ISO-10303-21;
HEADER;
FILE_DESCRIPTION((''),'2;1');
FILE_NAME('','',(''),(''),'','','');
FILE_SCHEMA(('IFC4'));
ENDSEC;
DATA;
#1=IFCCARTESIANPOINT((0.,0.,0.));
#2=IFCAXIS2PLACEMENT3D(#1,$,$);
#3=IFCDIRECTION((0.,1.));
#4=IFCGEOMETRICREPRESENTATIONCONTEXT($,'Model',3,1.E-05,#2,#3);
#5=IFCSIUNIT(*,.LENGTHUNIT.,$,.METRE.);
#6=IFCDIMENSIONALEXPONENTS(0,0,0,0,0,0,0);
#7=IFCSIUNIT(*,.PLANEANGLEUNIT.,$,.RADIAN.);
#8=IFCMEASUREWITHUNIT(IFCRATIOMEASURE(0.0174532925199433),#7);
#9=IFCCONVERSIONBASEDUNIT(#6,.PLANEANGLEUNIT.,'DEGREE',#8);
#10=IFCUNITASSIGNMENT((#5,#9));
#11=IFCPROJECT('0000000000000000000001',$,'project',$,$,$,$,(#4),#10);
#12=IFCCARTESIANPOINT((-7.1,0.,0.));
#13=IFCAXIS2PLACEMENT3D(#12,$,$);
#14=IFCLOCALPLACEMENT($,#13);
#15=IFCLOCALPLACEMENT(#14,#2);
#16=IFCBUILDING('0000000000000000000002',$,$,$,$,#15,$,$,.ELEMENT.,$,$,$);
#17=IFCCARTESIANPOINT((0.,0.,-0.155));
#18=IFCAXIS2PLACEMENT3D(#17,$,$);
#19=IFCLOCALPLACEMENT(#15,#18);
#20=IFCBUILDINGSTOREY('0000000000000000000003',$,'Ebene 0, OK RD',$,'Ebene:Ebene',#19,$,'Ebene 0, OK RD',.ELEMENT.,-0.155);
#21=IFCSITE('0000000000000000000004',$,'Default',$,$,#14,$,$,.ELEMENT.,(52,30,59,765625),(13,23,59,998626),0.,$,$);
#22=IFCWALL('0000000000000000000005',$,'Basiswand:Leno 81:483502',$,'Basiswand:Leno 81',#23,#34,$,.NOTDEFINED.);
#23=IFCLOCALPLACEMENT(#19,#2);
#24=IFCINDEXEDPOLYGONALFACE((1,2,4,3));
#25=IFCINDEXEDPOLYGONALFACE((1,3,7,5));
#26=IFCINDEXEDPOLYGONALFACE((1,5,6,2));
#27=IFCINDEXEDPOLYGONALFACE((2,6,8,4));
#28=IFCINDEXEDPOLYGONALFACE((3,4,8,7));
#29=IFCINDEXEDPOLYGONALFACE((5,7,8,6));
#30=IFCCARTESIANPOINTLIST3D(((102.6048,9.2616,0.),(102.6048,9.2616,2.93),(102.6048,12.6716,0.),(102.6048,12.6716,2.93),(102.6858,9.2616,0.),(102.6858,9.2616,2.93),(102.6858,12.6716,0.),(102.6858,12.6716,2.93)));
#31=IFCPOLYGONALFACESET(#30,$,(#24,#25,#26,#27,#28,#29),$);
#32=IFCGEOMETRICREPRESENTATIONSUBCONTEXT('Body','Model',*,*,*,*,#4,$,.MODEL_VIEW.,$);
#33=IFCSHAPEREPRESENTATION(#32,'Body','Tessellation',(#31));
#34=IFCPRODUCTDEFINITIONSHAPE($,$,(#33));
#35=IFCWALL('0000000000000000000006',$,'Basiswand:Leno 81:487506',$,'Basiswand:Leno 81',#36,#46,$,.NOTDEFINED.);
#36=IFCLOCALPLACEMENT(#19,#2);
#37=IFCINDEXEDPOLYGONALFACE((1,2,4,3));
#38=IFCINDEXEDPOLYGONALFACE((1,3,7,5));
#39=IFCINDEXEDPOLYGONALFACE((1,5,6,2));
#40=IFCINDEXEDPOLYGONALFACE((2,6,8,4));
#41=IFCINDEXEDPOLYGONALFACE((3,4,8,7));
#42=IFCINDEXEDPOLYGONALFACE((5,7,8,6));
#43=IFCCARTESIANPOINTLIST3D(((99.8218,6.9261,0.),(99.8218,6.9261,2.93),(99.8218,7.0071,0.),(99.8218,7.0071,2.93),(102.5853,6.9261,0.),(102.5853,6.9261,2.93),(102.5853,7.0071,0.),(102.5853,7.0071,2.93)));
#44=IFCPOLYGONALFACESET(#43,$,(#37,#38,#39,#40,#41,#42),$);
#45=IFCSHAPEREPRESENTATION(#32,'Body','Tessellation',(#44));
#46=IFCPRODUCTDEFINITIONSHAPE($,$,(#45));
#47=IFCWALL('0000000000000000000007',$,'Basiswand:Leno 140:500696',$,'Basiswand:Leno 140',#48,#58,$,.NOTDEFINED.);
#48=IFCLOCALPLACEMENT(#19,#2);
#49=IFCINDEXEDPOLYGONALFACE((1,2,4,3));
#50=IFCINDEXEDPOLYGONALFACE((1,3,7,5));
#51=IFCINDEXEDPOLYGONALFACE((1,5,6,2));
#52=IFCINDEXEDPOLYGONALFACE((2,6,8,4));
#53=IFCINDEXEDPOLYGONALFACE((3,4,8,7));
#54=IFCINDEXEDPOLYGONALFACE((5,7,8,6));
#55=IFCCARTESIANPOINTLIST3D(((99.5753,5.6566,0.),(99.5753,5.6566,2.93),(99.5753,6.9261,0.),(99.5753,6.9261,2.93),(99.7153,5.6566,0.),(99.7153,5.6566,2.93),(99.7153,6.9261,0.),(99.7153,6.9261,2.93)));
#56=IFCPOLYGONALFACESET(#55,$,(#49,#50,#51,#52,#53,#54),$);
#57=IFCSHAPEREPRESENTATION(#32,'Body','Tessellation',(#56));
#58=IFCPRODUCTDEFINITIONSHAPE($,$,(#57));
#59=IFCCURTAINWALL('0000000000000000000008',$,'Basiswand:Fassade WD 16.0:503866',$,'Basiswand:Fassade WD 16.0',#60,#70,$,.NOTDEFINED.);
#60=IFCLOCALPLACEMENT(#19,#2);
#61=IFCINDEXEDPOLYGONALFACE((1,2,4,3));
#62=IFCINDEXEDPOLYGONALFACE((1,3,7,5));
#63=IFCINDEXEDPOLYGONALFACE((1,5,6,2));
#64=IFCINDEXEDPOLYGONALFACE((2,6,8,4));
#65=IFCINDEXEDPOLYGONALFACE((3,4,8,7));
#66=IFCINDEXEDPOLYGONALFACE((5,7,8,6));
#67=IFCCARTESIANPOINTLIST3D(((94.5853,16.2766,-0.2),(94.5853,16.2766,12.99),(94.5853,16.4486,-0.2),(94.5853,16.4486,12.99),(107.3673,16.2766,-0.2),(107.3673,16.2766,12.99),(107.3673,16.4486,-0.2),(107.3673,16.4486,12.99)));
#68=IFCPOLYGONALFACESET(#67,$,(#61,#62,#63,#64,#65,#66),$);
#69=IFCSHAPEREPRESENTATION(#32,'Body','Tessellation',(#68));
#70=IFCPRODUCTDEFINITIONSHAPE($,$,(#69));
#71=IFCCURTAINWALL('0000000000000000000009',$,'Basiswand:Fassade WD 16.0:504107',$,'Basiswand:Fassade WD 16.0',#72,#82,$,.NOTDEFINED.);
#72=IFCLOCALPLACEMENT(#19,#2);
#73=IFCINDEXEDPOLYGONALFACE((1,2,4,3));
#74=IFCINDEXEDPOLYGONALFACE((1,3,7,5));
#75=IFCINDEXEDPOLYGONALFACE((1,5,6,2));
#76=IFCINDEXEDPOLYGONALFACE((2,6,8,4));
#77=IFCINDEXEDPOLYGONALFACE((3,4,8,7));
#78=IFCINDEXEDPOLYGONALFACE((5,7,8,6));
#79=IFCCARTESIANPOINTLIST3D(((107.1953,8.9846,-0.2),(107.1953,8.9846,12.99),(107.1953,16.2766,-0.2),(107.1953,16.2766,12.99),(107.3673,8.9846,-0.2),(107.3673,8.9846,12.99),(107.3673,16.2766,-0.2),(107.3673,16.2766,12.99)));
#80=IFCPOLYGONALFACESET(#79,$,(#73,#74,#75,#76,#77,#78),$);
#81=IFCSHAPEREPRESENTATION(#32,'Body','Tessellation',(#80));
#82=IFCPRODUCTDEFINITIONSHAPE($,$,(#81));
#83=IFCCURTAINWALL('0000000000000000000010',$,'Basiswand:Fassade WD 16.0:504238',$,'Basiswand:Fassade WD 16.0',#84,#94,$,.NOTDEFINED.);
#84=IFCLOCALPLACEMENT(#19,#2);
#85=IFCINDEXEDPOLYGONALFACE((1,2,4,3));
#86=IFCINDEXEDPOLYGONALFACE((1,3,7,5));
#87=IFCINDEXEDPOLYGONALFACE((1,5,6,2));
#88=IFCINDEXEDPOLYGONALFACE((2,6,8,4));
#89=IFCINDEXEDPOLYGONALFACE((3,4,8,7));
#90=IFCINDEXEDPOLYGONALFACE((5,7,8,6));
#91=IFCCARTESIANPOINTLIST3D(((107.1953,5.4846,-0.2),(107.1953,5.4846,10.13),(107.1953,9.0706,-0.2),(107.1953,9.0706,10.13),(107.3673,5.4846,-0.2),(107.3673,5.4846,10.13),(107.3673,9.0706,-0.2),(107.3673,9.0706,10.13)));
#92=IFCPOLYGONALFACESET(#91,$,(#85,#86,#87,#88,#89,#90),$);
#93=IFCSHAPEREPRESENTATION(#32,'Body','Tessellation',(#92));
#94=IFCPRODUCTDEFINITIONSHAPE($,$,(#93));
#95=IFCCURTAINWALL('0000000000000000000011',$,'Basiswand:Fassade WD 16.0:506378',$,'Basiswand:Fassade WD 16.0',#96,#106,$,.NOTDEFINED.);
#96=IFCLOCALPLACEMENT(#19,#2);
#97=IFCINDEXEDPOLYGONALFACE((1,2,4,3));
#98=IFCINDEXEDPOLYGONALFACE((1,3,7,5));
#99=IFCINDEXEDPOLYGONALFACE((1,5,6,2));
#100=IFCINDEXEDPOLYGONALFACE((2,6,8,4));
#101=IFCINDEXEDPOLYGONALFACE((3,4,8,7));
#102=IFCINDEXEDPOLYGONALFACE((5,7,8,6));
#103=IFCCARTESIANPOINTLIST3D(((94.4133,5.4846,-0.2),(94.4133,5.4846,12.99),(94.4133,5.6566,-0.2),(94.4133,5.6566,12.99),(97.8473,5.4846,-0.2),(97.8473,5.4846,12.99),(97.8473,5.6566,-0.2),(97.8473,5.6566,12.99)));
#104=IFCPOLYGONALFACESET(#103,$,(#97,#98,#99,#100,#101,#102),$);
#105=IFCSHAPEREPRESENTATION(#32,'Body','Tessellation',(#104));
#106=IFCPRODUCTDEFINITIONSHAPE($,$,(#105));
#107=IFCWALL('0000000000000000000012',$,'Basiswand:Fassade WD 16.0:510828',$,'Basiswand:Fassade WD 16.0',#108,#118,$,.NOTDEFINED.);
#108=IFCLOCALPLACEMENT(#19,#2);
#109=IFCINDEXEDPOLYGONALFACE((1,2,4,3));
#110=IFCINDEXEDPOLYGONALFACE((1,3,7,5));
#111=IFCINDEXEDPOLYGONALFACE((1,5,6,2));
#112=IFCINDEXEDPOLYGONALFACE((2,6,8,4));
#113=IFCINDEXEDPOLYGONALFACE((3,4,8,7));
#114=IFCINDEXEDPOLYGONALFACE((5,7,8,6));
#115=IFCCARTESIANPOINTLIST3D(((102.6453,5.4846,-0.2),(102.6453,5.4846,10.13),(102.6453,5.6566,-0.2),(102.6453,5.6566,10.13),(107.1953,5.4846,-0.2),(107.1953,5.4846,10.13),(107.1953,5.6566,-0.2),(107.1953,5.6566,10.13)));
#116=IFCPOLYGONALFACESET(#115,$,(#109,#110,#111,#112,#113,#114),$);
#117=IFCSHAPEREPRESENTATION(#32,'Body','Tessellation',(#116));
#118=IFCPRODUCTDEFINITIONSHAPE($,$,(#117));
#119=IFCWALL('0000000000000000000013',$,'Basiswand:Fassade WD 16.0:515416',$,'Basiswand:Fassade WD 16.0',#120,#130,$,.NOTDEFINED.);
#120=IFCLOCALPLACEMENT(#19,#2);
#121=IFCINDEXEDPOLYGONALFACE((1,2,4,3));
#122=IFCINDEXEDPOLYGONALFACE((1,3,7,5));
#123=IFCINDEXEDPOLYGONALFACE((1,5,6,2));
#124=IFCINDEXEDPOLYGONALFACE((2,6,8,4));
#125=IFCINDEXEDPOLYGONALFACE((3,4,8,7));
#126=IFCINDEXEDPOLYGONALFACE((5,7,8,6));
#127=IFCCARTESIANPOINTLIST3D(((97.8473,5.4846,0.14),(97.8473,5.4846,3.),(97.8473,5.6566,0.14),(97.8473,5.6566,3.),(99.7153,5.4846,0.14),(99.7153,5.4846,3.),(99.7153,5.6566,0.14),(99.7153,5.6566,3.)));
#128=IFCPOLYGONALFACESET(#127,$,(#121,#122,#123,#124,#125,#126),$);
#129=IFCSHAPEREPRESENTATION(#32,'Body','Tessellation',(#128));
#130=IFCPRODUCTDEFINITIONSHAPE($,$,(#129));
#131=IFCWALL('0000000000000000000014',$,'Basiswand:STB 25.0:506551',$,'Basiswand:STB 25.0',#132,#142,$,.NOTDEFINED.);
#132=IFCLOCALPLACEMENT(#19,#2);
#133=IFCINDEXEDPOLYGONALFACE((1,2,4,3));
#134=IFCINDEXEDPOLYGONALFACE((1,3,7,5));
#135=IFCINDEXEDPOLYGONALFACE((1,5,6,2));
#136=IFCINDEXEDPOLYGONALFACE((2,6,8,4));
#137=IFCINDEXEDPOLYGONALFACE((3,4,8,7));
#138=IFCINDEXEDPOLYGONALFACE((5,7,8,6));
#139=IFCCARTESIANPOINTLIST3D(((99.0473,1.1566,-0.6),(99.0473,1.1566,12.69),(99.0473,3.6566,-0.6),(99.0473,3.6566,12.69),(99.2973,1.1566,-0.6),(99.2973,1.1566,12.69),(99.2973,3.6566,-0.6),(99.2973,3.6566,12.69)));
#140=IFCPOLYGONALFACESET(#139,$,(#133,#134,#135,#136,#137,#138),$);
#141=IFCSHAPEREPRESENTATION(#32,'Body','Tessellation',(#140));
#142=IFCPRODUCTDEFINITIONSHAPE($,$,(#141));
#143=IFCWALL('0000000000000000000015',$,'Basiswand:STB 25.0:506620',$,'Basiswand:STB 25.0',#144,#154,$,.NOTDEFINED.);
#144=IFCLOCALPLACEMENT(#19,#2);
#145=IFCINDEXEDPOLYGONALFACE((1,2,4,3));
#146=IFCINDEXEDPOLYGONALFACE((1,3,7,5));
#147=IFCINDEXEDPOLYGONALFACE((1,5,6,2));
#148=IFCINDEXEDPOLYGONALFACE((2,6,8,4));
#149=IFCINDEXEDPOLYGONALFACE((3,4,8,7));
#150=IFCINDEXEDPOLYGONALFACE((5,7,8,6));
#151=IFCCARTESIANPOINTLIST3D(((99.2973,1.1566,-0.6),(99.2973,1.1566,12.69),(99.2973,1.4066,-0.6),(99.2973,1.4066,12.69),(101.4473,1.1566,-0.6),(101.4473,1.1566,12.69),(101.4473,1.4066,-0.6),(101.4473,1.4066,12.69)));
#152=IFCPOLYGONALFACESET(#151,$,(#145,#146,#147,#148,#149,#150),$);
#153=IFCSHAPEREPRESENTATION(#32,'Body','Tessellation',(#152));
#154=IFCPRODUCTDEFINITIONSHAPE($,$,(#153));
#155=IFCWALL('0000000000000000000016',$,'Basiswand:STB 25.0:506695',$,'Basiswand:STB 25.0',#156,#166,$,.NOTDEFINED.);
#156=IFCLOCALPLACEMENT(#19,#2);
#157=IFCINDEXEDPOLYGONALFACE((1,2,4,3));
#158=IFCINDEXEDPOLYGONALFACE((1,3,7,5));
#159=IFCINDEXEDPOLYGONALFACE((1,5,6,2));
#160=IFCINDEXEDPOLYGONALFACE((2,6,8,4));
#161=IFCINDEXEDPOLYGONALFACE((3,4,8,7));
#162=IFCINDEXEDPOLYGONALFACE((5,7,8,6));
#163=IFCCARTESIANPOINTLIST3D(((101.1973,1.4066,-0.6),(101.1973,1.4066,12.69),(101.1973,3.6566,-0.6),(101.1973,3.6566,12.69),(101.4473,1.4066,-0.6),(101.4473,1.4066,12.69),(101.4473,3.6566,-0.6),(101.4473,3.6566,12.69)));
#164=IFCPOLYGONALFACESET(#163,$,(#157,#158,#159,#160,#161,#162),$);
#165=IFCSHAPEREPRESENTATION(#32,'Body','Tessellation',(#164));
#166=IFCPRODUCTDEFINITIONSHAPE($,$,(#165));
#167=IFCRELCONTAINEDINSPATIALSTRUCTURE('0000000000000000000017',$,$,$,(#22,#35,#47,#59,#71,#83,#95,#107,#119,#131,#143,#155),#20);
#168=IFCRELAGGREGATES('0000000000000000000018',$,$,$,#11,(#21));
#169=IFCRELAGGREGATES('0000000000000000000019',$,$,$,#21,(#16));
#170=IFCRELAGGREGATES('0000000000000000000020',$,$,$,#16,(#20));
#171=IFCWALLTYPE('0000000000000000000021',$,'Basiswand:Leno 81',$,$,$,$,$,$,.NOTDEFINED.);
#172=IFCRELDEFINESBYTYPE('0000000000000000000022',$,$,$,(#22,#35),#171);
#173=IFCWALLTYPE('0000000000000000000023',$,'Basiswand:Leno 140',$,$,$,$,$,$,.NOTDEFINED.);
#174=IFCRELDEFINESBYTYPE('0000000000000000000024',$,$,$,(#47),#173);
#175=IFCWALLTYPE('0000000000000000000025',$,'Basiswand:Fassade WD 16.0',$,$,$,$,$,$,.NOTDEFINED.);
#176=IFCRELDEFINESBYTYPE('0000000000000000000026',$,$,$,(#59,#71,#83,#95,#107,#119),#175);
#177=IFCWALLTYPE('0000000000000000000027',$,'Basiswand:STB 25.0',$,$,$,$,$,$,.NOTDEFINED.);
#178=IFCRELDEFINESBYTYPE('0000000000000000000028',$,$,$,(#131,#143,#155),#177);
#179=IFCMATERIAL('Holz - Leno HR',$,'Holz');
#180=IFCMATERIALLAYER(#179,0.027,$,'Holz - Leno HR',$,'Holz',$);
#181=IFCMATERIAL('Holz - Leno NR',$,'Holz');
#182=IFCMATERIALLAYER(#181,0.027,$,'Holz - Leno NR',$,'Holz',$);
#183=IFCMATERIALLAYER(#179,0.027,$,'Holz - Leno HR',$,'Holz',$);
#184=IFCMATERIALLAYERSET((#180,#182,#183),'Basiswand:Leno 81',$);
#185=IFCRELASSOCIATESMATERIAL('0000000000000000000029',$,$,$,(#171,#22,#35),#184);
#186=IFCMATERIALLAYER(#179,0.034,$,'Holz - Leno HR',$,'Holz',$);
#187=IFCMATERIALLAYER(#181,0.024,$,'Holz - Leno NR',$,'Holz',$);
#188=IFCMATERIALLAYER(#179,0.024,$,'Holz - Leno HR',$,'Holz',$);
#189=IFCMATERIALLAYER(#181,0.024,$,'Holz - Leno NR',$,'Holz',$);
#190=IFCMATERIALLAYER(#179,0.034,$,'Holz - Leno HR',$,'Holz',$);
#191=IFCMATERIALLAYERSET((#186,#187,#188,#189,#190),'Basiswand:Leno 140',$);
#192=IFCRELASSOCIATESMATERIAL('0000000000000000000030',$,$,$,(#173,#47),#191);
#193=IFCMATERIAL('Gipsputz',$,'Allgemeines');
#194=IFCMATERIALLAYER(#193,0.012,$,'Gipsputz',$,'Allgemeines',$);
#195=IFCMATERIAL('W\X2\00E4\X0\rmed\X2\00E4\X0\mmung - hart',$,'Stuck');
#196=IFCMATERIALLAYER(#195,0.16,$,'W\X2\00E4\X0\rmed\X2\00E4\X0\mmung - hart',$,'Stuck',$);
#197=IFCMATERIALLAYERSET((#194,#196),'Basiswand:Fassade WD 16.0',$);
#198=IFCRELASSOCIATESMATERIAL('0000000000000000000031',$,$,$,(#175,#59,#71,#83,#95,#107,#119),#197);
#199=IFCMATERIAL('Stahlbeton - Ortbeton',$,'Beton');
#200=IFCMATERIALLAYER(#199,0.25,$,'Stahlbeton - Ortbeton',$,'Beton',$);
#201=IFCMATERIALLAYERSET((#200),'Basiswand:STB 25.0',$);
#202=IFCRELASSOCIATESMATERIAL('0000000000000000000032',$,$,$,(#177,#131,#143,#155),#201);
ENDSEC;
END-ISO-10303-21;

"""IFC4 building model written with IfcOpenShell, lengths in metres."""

from ifc_helpers import new_model, entity, si_unit, converted_unit, direction, frame, frame_2d, origin, place, context, subcontext, project, spatial, rectangle, extrude, material, layer, layer_set, layer_usage, type_object, element, save


model = new_model("IFC4")

# Units and contexts
model_context = context("Model", 3, precision=1e-05, world=origin(), true_north=direction((0.0, 1.0)))
body_context = subcontext(model_context, "Body", "Model", "MODEL_VIEW")
ifc_project = project(units=[si_unit("LENGTHUNIT", "METRE"), converted_unit("PLANEANGLEUNIT", "DEGREE", entity("IfcRatioMeasure", 0.0174532925199433), si_unit("PLANEANGLEUNIT", "RADIAN"), dimensions=[0, 0, 0, 0, 0, 0, 0])], contexts=[model_context])

# Site, building, storey
site_placement = place(None, frame((-7.1, 0.0, 0.0)))
site = spatial("IfcSite", under=ifc_project, at=site_placement, Name="Default", CompositionType="ELEMENT", RefLatitude=(52, 30, 59, 765625), RefLongitude=(13, 23, 59, 998626), RefElevation=0.0)
building_placement = place(site_placement, origin())
building = spatial("IfcBuilding", under=site, at=building_placement, CompositionType="ELEMENT")
storey_placement = place(building_placement, frame((0.0, 0.0, -0.155)))
storey = spatial("IfcBuildingStorey", under=building, at=storey_placement, Name="Ebene 0, OK RD", ObjectType="Ebene:Ebene", LongName="Ebene 0, OK RD", CompositionType="ELEMENT", Elevation=-0.155)

# Walls
ifc_material_1 = material(Name="Holz - Leno HR", Category="Holz")
ifc_material_2 = material(Name="Holz - Leno NR", Category="Holz")
ifc_layer_1 = layer(ifc_material_1, 0.027, Name="Holz - Leno HR", Category="Holz")
ifc_layer_2 = layer(ifc_material_2, 0.027, Name="Holz - Leno NR", Category="Holz")
ifc_layer_3 = layer(ifc_material_1, 0.027, Name="Holz - Leno HR", Category="Holz")
ifc_layer_set_1 = layer_set([ifc_layer_1, ifc_layer_2, ifc_layer_3], Name="Basiswand:Leno 81")
ifc_layer_usage_1 = layer_usage(ifc_layer_set_1, "AXIS2", "NEGATIVE", 0.0405)
wall_type_1 = type_object("IfcWallType", Name="Basiswand:Leno 81", PredefinedType="NOTDEFINED", material=ifc_layer_set_1)
wall_1_placement = place(storey_placement, frame((102.6453, 9.2616, 0.0), z_axis=(0.0, 0.0, 1.0), x_axis=(0.0, 1.0, 0.0)))
element("IfcWall", 1, at=wall_1_placement, inside=storey, type_object=wall_type_1, material=ifc_layer_usage_1, Name="Basiswand:Leno 81:483502", ObjectType="Basiswand:Leno 81", PredefinedType="NOTDEFINED", context=body_context, shape_type="SweptSolid", body=[
    extrude(rectangle(XDim=3.41, YDim=0.081, at=frame_2d((1.705, 0.0), x_axis=(-1.0, 0.0))), origin(), (0.0, 0.0, 1.0), 2.93),
])
ifc_layer_usage_2 = layer_usage(ifc_layer_set_1, "AXIS2", "NEGATIVE", 0.0405)
wall_2_placement = place(storey_placement, frame((99.8218, 6.9666, 0.0)))
element("IfcWall", 2, at=wall_2_placement, inside=storey, type_object=wall_type_1, material=ifc_layer_usage_2, Name="Basiswand:Leno 81:487506", ObjectType="Basiswand:Leno 81", PredefinedType="NOTDEFINED", context=body_context, shape_type="SweptSolid", body=[
    extrude(rectangle(XDim=2.7635, YDim=0.081, at=frame_2d((1.3817, 0.0), x_axis=(-1.0, 0.0))), origin(), (0.0, 0.0, 1.0), 2.93),
])
ifc_layer_4 = layer(ifc_material_1, 0.034, Name="Holz - Leno HR", Category="Holz")
ifc_layer_5 = layer(ifc_material_2, 0.024, Name="Holz - Leno NR", Category="Holz")
ifc_layer_6 = layer(ifc_material_1, 0.024, Name="Holz - Leno HR", Category="Holz")
ifc_layer_7 = layer(ifc_material_2, 0.024, Name="Holz - Leno NR", Category="Holz")
ifc_layer_8 = layer(ifc_material_1, 0.034, Name="Holz - Leno HR", Category="Holz")
ifc_layer_set_2 = layer_set([ifc_layer_4, ifc_layer_5, ifc_layer_6, ifc_layer_7, ifc_layer_8], Name="Basiswand:Leno 140")
ifc_layer_usage_3 = layer_usage(ifc_layer_set_2, "AXIS2", "NEGATIVE", 0.07)
wall_type_2 = type_object("IfcWallType", Name="Basiswand:Leno 140", PredefinedType="NOTDEFINED", material=ifc_layer_set_2)
wall_3_placement = place(storey_placement, frame((99.6453, 6.9261, 0.0), z_axis=(0.0, 0.0, 1.0), x_axis=(0.0, -1.0, 0.0)))
element("IfcWall", 3, at=wall_3_placement, inside=storey, type_object=wall_type_2, material=ifc_layer_usage_3, Name="Basiswand:Leno 140:500696", ObjectType="Basiswand:Leno 140", PredefinedType="NOTDEFINED", context=body_context, shape_type="SweptSolid", body=[
    extrude(rectangle(XDim=1.2695, YDim=0.14, at=frame_2d((0.6348, 0.0), x_axis=(-1.0, 0.0))), origin(), (0.0, 0.0, 1.0), 2.93),
])

# Curtain walls
ifc_material_3 = material(Name="Gipsputz", Category="Allgemeines")
ifc_layer_9 = layer(ifc_material_3, 0.012, Name="Gipsputz", Category="Allgemeines")
ifc_material_4 = material(Name="Wärmedämmung - hart", Category="Stuck")
ifc_layer_10 = layer(ifc_material_4, 0.16, Name="Wärmedämmung - hart", Category="Stuck")
ifc_layer_set_3 = layer_set([ifc_layer_9, ifc_layer_10], Name="Basiswand:Fassade WD 16.0")
ifc_layer_usage_4 = layer_usage(ifc_layer_set_3, "AXIS2", "NEGATIVE", 0.086)
wall_type_3 = type_object("IfcWallType", Name="Basiswand:Fassade WD 16.0", PredefinedType="NOTDEFINED", material=ifc_layer_set_3)
curtain_wall_1_placement = place(storey_placement, frame((94.5853, 16.3626, -0.2)))
element("IfcCurtainWall", 4, at=curtain_wall_1_placement, inside=storey, type_object=wall_type_3, material=ifc_layer_usage_4, Name="Basiswand:Fassade WD 16.0:503866", ObjectType="Basiswand:Fassade WD 16.0", PredefinedType="NOTDEFINED", context=body_context, shape_type="SweptSolid", body=[
    extrude(rectangle(XDim=12.782, YDim=0.172, at=frame_2d((6.391, 0.0), x_axis=(-1.0, 0.0))), origin(), (0.0, 0.0, 1.0), 13.19),
])
ifc_layer_usage_5 = layer_usage(ifc_layer_set_3, "AXIS2", "NEGATIVE", 0.086)
curtain_wall_2_placement = place(storey_placement, frame((107.2813, 16.2766, -0.2), z_axis=(0.0, 0.0, 1.0), x_axis=(0.0, -1.0, 0.0)))
element("IfcCurtainWall", 5, at=curtain_wall_2_placement, inside=storey, type_object=wall_type_3, material=ifc_layer_usage_5, Name="Basiswand:Fassade WD 16.0:504107", ObjectType="Basiswand:Fassade WD 16.0", PredefinedType="NOTDEFINED", context=body_context, shape_type="SweptSolid", body=[
    extrude(rectangle(XDim=7.292, YDim=0.172, at=frame_2d((3.646, 0.0), x_axis=(-1.0, 0.0))), origin(), (0.0, 0.0, 1.0), 13.19),
])
ifc_layer_usage_6 = layer_usage(ifc_layer_set_3, "AXIS2", "NEGATIVE", 0.086)
curtain_wall_3_placement = place(storey_placement, frame((107.2813, 9.0706, -0.2), z_axis=(0.0, 0.0, 1.0), x_axis=(0.0, -1.0, 0.0)))
element("IfcCurtainWall", 6, at=curtain_wall_3_placement, inside=storey, type_object=wall_type_3, material=ifc_layer_usage_6, Name="Basiswand:Fassade WD 16.0:504238", ObjectType="Basiswand:Fassade WD 16.0", PredefinedType="NOTDEFINED", context=body_context, shape_type="SweptSolid", body=[
    extrude(rectangle(XDim=3.586, YDim=0.172, at=frame_2d((1.793, 0.0), x_axis=(-1.0, 0.0))), origin(), (0.0, 0.0, 1.0), 10.33),
])
ifc_layer_usage_7 = layer_usage(ifc_layer_set_3, "AXIS2", "NEGATIVE", 0.086)
curtain_wall_4_placement = place(storey_placement, frame((97.8473, 5.5706, -0.2), z_axis=(0.0, 0.0, 1.0), x_axis=(-1.0, 0.0, 0.0)))
element("IfcCurtainWall", 7, at=curtain_wall_4_placement, inside=storey, type_object=wall_type_3, material=ifc_layer_usage_7, Name="Basiswand:Fassade WD 16.0:506378", ObjectType="Basiswand:Fassade WD 16.0", PredefinedType="NOTDEFINED", context=body_context, shape_type="SweptSolid", body=[
    extrude(rectangle(XDim=3.434, YDim=0.172, at=frame_2d((1.717, 0.0), x_axis=(-1.0, 0.0))), origin(), (0.0, 0.0, 1.0), 13.19),
])

# Walls
ifc_layer_usage_8 = layer_usage(ifc_layer_set_3, "AXIS2", "NEGATIVE", 0.086)
wall_4_placement = place(storey_placement, frame((107.1953, 5.5706, -0.2), z_axis=(0.0, 0.0, 1.0), x_axis=(-1.0, 0.0, 0.0)))
element("IfcWall", 8, at=wall_4_placement, inside=storey, type_object=wall_type_3, material=ifc_layer_usage_8, Name="Basiswand:Fassade WD 16.0:510828", ObjectType="Basiswand:Fassade WD 16.0", PredefinedType="NOTDEFINED", context=body_context, shape_type="SweptSolid", body=[
    extrude(rectangle(XDim=4.55, YDim=0.172, at=frame_2d((2.275, 0.0), x_axis=(-1.0, 0.0))), origin(), (0.0, 0.0, 1.0), 10.33),
])
ifc_layer_usage_9 = layer_usage(ifc_layer_set_3, "AXIS2", "NEGATIVE", 0.086)
wall_5_placement = place(storey_placement, frame((99.7153, 5.5706, 0.14), z_axis=(0.0, 0.0, 1.0), x_axis=(-1.0, 0.0, 0.0)))
element("IfcWall", 9, at=wall_5_placement, inside=storey, type_object=wall_type_3, material=ifc_layer_usage_9, Name="Basiswand:Fassade WD 16.0:515416", ObjectType="Basiswand:Fassade WD 16.0", PredefinedType="NOTDEFINED", context=body_context, shape_type="SweptSolid", body=[
    extrude(rectangle(XDim=1.868, YDim=0.172, at=frame_2d((0.934, 0.0), x_axis=(-1.0, 0.0))), origin(), (0.0, 0.0, 1.0), 2.86),
])
ifc_material_5 = material(Name="Stahlbeton - Ortbeton", Category="Beton")
ifc_layer_11 = layer(ifc_material_5, 0.25, Name="Stahlbeton - Ortbeton", Category="Beton")
ifc_layer_set_4 = layer_set([ifc_layer_11], Name="Basiswand:STB 25.0")
ifc_layer_usage_10 = layer_usage(ifc_layer_set_4, "AXIS2", "NEGATIVE", 0.125)
wall_type_4 = type_object("IfcWallType", Name="Basiswand:STB 25.0", PredefinedType="NOTDEFINED", material=ifc_layer_set_4)
wall_6_placement = place(storey_placement, frame((99.1723, 3.6566, -0.6), z_axis=(0.0, 0.0, 1.0), x_axis=(0.0, -1.0, 0.0)))
element("IfcWall", 10, at=wall_6_placement, inside=storey, type_object=wall_type_4, material=ifc_layer_usage_10, Name="Basiswand:STB 25.0:506551", ObjectType="Basiswand:STB 25.0", PredefinedType="NOTDEFINED", context=body_context, shape_type="SweptSolid", body=[
    extrude(rectangle(XDim=2.5, YDim=0.25, at=frame_2d((1.25, 0.0), x_axis=(-1.0, 0.0))), origin(), (0.0, 0.0, 1.0), 13.29),
])
ifc_layer_usage_11 = layer_usage(ifc_layer_set_4, "AXIS2", "NEGATIVE", 0.125)
wall_7_placement = place(storey_placement, frame((99.2973, 1.2816, -0.6)))
element("IfcWall", 11, at=wall_7_placement, inside=storey, type_object=wall_type_4, material=ifc_layer_usage_11, Name="Basiswand:STB 25.0:506620", ObjectType="Basiswand:STB 25.0", PredefinedType="NOTDEFINED", context=body_context, shape_type="SweptSolid", body=[
    extrude(rectangle(XDim=2.15, YDim=0.25, at=frame_2d((1.075, 0.0), x_axis=(-1.0, 0.0))), origin(), (0.0, 0.0, 1.0), 13.29),
])
ifc_layer_usage_12 = layer_usage(ifc_layer_set_4, "AXIS2", "NEGATIVE", 0.125)
wall_8_placement = place(storey_placement, frame((101.3223, 1.4066, -0.6), z_axis=(0.0, 0.0, 1.0), x_axis=(0.0, 1.0, 0.0)))
element("IfcWall", 12, at=wall_8_placement, inside=storey, type_object=wall_type_4, material=ifc_layer_usage_12, Name="Basiswand:STB 25.0:506695", ObjectType="Basiswand:STB 25.0", PredefinedType="NOTDEFINED", context=body_context, shape_type="SweptSolid", body=[
    extrude(rectangle(XDim=2.25, YDim=0.25, at=frame_2d((1.125, 0.0), x_axis=(-1.0, 0.0))), origin(), (0.0, 0.0, 1.0), 13.29),
])

save(model, "model.ifc")
